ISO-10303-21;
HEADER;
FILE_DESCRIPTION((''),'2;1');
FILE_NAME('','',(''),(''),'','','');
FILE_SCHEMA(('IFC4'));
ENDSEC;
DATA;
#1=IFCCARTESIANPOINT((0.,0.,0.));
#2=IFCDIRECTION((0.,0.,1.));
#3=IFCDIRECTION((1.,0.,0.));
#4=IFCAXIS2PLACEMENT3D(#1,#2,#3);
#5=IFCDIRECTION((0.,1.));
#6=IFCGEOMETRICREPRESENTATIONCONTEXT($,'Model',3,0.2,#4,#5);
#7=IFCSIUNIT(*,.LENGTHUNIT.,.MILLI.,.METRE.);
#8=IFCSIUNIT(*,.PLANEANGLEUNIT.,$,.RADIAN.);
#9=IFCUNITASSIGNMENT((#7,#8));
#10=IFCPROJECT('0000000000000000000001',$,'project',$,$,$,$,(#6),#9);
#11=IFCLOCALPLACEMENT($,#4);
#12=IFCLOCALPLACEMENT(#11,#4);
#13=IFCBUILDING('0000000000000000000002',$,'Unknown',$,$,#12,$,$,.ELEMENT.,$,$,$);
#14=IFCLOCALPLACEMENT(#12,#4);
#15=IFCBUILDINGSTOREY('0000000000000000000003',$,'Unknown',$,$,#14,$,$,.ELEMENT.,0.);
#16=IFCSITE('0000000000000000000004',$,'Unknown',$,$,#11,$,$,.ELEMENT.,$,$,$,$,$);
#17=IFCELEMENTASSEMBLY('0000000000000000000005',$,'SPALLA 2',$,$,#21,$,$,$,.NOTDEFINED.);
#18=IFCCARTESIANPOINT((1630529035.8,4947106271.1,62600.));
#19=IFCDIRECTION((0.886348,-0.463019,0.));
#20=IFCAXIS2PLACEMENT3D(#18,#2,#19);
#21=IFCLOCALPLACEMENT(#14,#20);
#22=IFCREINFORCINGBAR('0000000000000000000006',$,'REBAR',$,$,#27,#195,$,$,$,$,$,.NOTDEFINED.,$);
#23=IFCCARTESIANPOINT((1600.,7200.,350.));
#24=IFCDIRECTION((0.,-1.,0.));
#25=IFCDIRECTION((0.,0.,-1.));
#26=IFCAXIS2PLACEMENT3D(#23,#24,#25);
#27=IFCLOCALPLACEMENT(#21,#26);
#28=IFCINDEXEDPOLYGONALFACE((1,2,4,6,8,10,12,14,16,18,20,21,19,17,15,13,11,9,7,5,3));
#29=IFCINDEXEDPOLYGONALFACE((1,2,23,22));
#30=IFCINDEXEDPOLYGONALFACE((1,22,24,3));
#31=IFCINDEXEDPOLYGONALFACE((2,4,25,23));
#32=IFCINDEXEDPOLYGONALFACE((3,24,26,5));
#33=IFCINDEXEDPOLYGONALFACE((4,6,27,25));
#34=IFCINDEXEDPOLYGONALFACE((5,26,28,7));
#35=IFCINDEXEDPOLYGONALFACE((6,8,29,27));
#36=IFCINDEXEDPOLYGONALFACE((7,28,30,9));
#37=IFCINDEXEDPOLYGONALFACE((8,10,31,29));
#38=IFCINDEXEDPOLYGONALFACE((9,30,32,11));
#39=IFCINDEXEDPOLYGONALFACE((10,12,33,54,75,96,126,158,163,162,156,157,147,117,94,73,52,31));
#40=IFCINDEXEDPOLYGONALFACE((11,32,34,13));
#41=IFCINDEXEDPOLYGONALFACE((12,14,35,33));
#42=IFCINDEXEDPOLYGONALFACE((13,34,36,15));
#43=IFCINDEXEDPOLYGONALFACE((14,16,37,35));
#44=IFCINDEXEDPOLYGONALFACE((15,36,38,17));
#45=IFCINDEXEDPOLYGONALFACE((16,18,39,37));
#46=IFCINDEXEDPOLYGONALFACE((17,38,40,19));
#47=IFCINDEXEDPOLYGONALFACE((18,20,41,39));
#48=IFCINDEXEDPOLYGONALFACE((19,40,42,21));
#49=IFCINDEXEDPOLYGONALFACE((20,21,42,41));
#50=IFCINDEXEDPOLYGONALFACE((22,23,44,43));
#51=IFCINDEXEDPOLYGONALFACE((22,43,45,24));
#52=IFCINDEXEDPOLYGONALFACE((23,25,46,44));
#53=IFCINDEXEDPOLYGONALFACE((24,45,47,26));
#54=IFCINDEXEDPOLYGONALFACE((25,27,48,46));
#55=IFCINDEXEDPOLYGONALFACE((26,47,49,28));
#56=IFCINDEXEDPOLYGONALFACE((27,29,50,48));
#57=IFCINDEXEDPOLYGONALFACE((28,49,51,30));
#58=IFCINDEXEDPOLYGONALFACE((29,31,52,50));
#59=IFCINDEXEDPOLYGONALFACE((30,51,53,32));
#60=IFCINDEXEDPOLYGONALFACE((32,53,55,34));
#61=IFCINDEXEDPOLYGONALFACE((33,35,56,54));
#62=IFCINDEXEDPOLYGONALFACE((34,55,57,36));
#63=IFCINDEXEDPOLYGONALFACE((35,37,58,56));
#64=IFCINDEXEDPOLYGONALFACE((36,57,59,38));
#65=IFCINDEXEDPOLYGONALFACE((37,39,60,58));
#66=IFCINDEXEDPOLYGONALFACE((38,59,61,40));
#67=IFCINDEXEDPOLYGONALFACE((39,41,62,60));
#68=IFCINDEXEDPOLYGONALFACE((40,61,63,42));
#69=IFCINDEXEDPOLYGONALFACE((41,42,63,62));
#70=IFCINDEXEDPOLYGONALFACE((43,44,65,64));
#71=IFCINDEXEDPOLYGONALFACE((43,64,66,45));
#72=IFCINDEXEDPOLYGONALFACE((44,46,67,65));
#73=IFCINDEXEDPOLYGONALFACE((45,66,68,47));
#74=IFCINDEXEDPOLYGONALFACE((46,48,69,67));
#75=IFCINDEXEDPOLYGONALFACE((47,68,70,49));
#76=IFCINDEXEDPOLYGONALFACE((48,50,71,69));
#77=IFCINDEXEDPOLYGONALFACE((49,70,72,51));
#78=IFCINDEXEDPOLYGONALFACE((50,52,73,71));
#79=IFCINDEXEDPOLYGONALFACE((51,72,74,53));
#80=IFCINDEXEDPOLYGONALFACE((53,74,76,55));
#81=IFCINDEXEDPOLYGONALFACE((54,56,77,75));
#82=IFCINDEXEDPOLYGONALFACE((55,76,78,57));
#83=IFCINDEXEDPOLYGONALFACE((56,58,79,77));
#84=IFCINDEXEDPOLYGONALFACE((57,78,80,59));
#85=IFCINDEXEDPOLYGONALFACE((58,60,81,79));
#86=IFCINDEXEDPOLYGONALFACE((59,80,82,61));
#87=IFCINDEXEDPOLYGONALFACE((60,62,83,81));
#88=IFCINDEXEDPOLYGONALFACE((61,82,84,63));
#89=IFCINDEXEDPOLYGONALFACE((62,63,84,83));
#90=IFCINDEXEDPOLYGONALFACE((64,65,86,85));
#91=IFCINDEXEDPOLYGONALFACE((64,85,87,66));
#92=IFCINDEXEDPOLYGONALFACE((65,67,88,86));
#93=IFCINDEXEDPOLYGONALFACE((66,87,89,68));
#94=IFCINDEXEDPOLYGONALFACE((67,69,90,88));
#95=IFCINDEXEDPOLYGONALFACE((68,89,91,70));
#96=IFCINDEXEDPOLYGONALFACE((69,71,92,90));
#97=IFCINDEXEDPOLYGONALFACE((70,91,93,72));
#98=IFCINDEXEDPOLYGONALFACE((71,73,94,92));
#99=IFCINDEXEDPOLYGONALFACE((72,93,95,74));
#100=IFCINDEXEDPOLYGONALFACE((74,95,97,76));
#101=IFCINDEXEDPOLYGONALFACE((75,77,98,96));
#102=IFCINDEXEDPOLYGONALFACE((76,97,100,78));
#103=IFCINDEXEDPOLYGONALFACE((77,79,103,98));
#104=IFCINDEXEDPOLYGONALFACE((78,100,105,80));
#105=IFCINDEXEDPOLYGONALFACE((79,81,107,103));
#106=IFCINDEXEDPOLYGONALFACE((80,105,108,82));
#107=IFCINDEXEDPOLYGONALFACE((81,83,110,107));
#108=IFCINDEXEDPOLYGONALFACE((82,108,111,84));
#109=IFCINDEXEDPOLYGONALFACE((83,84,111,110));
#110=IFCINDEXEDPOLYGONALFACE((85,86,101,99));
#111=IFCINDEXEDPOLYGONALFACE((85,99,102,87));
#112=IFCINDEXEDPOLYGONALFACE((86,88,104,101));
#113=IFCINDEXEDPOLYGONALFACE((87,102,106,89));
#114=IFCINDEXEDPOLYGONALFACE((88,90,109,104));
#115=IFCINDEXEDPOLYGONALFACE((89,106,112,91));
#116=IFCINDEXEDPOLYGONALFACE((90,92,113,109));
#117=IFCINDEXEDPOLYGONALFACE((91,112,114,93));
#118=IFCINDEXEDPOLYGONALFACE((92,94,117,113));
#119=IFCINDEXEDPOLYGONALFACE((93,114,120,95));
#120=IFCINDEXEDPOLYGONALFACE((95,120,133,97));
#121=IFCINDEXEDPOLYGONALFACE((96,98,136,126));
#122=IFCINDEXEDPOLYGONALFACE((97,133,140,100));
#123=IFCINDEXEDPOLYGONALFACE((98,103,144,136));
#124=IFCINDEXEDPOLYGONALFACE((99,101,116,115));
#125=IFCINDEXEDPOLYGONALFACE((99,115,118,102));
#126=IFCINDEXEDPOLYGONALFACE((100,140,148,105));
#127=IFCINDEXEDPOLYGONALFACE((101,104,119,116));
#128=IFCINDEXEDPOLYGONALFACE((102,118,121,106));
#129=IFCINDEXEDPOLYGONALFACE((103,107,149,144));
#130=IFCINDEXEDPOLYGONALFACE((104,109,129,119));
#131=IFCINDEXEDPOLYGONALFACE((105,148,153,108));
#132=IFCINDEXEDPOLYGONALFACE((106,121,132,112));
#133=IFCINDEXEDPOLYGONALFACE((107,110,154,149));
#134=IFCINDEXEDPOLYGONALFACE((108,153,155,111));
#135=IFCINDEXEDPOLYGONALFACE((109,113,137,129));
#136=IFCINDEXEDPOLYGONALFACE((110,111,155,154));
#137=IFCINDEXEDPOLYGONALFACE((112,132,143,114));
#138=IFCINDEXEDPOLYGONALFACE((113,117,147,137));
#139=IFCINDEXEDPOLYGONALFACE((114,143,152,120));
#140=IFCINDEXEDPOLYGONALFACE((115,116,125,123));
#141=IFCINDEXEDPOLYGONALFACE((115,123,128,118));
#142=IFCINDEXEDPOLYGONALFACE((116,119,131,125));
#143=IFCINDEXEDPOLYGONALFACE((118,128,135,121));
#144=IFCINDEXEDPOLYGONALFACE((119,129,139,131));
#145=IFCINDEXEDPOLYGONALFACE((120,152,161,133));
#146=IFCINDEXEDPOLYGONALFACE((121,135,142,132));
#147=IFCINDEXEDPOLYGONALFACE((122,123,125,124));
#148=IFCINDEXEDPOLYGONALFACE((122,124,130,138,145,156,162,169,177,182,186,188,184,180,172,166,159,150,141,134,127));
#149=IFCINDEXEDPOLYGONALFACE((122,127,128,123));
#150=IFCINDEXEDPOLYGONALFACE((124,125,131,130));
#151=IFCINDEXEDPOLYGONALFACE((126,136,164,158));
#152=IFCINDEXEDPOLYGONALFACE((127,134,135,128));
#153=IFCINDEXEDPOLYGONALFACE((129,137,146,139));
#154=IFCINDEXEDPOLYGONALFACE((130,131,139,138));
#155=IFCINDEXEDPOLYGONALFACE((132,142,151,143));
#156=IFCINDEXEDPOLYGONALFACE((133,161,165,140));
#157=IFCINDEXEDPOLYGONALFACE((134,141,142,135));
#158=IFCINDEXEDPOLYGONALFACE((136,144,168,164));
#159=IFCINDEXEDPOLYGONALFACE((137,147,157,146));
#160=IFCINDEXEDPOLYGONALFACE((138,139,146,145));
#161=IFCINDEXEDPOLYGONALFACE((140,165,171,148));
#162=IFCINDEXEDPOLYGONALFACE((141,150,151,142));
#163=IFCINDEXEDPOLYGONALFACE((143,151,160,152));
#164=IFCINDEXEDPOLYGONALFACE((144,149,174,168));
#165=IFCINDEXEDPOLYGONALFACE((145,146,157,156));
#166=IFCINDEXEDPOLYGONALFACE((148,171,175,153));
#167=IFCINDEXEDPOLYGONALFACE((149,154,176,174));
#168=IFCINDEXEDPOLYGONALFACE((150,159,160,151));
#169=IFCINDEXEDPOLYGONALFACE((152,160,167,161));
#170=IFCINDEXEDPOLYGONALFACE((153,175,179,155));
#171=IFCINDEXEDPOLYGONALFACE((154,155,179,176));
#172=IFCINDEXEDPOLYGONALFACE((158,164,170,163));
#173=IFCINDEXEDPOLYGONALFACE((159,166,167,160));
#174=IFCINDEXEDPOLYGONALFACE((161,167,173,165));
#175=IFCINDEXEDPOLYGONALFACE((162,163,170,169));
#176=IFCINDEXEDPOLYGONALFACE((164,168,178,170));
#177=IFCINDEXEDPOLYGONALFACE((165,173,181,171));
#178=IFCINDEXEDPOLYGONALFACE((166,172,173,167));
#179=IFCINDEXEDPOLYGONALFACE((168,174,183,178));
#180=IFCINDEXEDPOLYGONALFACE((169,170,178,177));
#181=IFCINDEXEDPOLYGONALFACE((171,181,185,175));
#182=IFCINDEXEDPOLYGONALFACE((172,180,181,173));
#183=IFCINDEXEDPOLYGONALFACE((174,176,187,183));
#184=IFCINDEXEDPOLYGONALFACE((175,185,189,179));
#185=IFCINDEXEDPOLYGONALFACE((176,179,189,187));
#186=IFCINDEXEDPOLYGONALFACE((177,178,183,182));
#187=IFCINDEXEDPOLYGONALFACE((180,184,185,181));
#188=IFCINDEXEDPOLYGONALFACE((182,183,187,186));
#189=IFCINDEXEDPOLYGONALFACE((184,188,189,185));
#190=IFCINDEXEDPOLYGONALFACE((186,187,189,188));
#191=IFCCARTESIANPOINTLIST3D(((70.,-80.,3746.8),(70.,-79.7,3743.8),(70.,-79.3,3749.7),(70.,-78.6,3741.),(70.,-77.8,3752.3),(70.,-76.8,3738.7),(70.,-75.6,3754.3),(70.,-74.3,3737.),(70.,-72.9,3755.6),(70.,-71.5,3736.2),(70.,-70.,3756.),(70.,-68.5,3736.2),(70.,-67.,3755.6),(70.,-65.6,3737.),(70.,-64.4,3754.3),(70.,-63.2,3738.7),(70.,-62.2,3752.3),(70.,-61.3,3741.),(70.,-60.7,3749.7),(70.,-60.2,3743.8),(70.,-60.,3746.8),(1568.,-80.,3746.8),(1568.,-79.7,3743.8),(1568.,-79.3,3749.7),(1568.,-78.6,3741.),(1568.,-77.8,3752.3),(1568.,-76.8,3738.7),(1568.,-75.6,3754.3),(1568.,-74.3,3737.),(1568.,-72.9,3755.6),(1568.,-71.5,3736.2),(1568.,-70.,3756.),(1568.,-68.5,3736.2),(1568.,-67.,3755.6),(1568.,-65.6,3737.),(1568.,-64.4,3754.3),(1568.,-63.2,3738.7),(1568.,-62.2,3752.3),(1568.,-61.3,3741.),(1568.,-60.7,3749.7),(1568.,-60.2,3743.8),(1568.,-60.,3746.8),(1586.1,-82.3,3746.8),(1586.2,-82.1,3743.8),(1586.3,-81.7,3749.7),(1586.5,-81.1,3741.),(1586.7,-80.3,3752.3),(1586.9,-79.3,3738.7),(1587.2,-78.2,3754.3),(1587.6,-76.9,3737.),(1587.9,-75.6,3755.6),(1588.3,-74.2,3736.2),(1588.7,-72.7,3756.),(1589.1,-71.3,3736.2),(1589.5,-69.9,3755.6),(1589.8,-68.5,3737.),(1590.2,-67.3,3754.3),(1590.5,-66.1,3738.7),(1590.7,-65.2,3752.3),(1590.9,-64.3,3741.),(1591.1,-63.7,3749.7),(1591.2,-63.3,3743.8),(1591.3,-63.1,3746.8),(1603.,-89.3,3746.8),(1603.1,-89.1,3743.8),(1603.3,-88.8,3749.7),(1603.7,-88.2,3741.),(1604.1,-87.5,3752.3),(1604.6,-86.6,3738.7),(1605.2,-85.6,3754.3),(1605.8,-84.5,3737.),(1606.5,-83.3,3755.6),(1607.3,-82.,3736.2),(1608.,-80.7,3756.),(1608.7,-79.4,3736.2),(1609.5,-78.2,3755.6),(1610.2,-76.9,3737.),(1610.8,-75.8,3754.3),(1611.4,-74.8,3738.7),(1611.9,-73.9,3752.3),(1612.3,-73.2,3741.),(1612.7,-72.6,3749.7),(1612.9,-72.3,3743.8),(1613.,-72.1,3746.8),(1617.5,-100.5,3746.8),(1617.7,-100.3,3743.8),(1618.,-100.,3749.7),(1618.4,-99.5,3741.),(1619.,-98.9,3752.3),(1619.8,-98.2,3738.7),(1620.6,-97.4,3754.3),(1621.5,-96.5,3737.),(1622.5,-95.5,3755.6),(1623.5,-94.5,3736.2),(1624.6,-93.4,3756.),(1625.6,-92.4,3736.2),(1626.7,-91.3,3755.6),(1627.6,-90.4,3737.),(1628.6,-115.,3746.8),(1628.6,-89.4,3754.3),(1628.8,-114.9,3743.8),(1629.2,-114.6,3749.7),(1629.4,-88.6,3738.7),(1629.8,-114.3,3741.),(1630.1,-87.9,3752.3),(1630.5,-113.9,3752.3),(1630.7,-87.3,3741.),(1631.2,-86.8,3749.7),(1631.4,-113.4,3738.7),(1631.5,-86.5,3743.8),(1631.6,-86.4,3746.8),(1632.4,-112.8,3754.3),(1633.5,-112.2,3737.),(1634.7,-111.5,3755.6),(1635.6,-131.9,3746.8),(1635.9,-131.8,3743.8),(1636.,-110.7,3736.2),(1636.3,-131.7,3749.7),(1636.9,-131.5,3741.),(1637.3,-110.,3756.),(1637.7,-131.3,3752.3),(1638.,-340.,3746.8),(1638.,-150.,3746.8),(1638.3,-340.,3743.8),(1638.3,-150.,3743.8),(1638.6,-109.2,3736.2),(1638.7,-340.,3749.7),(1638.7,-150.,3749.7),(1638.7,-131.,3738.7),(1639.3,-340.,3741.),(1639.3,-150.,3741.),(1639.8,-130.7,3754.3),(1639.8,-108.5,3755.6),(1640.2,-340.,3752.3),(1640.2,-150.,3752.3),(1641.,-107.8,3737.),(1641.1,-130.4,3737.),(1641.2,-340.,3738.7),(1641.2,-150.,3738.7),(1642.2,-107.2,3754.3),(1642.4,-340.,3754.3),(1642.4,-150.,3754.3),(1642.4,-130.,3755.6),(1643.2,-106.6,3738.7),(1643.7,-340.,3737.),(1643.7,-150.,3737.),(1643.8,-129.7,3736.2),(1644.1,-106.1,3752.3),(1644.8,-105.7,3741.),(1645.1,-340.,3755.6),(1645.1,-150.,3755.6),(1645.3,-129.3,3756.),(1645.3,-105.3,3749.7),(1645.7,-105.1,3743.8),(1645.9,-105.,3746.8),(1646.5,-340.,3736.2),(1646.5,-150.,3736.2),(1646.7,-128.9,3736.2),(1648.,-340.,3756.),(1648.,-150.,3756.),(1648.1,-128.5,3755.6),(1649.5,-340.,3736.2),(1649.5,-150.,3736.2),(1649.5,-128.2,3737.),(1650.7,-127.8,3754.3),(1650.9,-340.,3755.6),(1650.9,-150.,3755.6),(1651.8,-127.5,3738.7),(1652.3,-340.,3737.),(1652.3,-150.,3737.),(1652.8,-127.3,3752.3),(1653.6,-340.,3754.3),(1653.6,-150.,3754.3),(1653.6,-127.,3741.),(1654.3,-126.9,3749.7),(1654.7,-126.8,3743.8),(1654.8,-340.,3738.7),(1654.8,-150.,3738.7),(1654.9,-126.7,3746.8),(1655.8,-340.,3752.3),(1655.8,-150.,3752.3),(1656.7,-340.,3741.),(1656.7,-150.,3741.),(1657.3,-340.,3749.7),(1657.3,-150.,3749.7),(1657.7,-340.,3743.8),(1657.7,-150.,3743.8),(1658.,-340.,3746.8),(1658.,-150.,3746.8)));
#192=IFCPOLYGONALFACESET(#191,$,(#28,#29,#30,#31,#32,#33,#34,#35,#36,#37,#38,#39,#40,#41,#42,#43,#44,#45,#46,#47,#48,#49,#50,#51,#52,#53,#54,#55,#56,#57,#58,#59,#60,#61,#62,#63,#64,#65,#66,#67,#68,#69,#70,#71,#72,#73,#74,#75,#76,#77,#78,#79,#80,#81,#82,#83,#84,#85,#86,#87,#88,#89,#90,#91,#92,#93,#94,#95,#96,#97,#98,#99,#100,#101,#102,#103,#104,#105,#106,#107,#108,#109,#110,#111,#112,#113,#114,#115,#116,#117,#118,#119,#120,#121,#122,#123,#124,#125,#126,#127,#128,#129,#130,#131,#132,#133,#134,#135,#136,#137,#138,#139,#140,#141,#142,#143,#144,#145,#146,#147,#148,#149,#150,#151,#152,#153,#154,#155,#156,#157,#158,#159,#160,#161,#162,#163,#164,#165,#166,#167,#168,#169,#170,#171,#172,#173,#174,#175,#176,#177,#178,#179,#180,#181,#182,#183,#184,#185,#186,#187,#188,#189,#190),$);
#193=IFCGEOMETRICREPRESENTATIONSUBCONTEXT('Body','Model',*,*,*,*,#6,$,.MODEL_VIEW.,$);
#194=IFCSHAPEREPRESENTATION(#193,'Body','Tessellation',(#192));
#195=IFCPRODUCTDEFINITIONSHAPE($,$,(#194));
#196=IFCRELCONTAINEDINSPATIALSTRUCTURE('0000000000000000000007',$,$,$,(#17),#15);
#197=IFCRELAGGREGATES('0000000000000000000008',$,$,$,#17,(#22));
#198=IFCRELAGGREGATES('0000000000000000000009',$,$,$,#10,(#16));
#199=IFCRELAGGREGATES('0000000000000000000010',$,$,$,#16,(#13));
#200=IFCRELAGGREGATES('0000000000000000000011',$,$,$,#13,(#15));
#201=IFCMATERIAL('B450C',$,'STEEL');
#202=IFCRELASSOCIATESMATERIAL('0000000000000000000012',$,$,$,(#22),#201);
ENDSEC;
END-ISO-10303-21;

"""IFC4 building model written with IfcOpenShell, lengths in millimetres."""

from ifc_helpers import new_model, entity, si_unit, direction, frame, origin_with_axes, place, context, subcontext, project, spatial, material, element, aggregate, save


model = new_model("IFC4")

# Units and contexts
model_context = context("Model", 3, precision=0.2, world=origin_with_axes(), true_north=direction((0.0, 1.0)))
body_context = subcontext(model_context, "Body", "Model", "MODEL_VIEW")
ifc_project = project(units=[si_unit("LENGTHUNIT", "METRE", prefix="MILLI"), si_unit("PLANEANGLEUNIT", "RADIAN")], contexts=[model_context])

# Site, building, storey
site_placement = place(None, origin_with_axes())
site = spatial("IfcSite", under=ifc_project, at=site_placement, Name="Unknown", CompositionType="ELEMENT")
building_placement = place(site_placement, origin_with_axes())
building = spatial("IfcBuilding", under=site, at=building_placement, Name="Unknown", CompositionType="ELEMENT")
storey_placement = place(building_placement, origin_with_axes())
storey = spatial("IfcBuildingStorey", under=building, at=storey_placement, Name="Unknown", CompositionType="ELEMENT", Elevation=0.0)

# Element assembly
assembly_1_placement = place(storey_placement, frame((1630529035.8, 4947106271.1, 62600.0), z_axis=(0.0, 0.0, 1.0), x_axis=(0.886348, -0.463019, 0.0)))
assembly_1 = element("IfcElementAssembly", 1, at=assembly_1_placement, inside=storey, Name="SPALLA 2", PredefinedType="NOTDEFINED")
ifc_material = material(Name="B450C", Category="STEEL")

# Reinforcing bar
reinforcing_bar_1_placement = place(assembly_1_placement, frame((1600.0, 7200.0, 350.0), z_axis=(0.0, -1.0, 0.0), x_axis=(0.0, 0.0, -1.0)))
reinforcing_bar_1 = element("IfcReinforcingBar", 2, at=reinforcing_bar_1_placement, material=ifc_material, Name="REBAR", PredefinedType="NOTDEFINED", context=body_context, shape_type="AdvancedSweptSolid", body=[
    entity("IfcSweptDiskSolid", entity("IfcIndexedPolyCurve", entity("IfcCartesianPointList3D", [[70.0, -70.0, 3746.0], [1568.0, -70.0, 3746.0], [1624.6, -93.4, 3746.0], [1648.0, -150.0, 3746.0], [1648.0, -340.0, 3746.0]]), [entity("IfcLineIndex", [1, 2]), entity("IfcArcIndex", [2, 3, 4]), entity("IfcLineIndex", [4, 5])]), 10.0),
])
aggregate(assembly_1, [reinforcing_bar_1])

save(model, "model.ifc")
